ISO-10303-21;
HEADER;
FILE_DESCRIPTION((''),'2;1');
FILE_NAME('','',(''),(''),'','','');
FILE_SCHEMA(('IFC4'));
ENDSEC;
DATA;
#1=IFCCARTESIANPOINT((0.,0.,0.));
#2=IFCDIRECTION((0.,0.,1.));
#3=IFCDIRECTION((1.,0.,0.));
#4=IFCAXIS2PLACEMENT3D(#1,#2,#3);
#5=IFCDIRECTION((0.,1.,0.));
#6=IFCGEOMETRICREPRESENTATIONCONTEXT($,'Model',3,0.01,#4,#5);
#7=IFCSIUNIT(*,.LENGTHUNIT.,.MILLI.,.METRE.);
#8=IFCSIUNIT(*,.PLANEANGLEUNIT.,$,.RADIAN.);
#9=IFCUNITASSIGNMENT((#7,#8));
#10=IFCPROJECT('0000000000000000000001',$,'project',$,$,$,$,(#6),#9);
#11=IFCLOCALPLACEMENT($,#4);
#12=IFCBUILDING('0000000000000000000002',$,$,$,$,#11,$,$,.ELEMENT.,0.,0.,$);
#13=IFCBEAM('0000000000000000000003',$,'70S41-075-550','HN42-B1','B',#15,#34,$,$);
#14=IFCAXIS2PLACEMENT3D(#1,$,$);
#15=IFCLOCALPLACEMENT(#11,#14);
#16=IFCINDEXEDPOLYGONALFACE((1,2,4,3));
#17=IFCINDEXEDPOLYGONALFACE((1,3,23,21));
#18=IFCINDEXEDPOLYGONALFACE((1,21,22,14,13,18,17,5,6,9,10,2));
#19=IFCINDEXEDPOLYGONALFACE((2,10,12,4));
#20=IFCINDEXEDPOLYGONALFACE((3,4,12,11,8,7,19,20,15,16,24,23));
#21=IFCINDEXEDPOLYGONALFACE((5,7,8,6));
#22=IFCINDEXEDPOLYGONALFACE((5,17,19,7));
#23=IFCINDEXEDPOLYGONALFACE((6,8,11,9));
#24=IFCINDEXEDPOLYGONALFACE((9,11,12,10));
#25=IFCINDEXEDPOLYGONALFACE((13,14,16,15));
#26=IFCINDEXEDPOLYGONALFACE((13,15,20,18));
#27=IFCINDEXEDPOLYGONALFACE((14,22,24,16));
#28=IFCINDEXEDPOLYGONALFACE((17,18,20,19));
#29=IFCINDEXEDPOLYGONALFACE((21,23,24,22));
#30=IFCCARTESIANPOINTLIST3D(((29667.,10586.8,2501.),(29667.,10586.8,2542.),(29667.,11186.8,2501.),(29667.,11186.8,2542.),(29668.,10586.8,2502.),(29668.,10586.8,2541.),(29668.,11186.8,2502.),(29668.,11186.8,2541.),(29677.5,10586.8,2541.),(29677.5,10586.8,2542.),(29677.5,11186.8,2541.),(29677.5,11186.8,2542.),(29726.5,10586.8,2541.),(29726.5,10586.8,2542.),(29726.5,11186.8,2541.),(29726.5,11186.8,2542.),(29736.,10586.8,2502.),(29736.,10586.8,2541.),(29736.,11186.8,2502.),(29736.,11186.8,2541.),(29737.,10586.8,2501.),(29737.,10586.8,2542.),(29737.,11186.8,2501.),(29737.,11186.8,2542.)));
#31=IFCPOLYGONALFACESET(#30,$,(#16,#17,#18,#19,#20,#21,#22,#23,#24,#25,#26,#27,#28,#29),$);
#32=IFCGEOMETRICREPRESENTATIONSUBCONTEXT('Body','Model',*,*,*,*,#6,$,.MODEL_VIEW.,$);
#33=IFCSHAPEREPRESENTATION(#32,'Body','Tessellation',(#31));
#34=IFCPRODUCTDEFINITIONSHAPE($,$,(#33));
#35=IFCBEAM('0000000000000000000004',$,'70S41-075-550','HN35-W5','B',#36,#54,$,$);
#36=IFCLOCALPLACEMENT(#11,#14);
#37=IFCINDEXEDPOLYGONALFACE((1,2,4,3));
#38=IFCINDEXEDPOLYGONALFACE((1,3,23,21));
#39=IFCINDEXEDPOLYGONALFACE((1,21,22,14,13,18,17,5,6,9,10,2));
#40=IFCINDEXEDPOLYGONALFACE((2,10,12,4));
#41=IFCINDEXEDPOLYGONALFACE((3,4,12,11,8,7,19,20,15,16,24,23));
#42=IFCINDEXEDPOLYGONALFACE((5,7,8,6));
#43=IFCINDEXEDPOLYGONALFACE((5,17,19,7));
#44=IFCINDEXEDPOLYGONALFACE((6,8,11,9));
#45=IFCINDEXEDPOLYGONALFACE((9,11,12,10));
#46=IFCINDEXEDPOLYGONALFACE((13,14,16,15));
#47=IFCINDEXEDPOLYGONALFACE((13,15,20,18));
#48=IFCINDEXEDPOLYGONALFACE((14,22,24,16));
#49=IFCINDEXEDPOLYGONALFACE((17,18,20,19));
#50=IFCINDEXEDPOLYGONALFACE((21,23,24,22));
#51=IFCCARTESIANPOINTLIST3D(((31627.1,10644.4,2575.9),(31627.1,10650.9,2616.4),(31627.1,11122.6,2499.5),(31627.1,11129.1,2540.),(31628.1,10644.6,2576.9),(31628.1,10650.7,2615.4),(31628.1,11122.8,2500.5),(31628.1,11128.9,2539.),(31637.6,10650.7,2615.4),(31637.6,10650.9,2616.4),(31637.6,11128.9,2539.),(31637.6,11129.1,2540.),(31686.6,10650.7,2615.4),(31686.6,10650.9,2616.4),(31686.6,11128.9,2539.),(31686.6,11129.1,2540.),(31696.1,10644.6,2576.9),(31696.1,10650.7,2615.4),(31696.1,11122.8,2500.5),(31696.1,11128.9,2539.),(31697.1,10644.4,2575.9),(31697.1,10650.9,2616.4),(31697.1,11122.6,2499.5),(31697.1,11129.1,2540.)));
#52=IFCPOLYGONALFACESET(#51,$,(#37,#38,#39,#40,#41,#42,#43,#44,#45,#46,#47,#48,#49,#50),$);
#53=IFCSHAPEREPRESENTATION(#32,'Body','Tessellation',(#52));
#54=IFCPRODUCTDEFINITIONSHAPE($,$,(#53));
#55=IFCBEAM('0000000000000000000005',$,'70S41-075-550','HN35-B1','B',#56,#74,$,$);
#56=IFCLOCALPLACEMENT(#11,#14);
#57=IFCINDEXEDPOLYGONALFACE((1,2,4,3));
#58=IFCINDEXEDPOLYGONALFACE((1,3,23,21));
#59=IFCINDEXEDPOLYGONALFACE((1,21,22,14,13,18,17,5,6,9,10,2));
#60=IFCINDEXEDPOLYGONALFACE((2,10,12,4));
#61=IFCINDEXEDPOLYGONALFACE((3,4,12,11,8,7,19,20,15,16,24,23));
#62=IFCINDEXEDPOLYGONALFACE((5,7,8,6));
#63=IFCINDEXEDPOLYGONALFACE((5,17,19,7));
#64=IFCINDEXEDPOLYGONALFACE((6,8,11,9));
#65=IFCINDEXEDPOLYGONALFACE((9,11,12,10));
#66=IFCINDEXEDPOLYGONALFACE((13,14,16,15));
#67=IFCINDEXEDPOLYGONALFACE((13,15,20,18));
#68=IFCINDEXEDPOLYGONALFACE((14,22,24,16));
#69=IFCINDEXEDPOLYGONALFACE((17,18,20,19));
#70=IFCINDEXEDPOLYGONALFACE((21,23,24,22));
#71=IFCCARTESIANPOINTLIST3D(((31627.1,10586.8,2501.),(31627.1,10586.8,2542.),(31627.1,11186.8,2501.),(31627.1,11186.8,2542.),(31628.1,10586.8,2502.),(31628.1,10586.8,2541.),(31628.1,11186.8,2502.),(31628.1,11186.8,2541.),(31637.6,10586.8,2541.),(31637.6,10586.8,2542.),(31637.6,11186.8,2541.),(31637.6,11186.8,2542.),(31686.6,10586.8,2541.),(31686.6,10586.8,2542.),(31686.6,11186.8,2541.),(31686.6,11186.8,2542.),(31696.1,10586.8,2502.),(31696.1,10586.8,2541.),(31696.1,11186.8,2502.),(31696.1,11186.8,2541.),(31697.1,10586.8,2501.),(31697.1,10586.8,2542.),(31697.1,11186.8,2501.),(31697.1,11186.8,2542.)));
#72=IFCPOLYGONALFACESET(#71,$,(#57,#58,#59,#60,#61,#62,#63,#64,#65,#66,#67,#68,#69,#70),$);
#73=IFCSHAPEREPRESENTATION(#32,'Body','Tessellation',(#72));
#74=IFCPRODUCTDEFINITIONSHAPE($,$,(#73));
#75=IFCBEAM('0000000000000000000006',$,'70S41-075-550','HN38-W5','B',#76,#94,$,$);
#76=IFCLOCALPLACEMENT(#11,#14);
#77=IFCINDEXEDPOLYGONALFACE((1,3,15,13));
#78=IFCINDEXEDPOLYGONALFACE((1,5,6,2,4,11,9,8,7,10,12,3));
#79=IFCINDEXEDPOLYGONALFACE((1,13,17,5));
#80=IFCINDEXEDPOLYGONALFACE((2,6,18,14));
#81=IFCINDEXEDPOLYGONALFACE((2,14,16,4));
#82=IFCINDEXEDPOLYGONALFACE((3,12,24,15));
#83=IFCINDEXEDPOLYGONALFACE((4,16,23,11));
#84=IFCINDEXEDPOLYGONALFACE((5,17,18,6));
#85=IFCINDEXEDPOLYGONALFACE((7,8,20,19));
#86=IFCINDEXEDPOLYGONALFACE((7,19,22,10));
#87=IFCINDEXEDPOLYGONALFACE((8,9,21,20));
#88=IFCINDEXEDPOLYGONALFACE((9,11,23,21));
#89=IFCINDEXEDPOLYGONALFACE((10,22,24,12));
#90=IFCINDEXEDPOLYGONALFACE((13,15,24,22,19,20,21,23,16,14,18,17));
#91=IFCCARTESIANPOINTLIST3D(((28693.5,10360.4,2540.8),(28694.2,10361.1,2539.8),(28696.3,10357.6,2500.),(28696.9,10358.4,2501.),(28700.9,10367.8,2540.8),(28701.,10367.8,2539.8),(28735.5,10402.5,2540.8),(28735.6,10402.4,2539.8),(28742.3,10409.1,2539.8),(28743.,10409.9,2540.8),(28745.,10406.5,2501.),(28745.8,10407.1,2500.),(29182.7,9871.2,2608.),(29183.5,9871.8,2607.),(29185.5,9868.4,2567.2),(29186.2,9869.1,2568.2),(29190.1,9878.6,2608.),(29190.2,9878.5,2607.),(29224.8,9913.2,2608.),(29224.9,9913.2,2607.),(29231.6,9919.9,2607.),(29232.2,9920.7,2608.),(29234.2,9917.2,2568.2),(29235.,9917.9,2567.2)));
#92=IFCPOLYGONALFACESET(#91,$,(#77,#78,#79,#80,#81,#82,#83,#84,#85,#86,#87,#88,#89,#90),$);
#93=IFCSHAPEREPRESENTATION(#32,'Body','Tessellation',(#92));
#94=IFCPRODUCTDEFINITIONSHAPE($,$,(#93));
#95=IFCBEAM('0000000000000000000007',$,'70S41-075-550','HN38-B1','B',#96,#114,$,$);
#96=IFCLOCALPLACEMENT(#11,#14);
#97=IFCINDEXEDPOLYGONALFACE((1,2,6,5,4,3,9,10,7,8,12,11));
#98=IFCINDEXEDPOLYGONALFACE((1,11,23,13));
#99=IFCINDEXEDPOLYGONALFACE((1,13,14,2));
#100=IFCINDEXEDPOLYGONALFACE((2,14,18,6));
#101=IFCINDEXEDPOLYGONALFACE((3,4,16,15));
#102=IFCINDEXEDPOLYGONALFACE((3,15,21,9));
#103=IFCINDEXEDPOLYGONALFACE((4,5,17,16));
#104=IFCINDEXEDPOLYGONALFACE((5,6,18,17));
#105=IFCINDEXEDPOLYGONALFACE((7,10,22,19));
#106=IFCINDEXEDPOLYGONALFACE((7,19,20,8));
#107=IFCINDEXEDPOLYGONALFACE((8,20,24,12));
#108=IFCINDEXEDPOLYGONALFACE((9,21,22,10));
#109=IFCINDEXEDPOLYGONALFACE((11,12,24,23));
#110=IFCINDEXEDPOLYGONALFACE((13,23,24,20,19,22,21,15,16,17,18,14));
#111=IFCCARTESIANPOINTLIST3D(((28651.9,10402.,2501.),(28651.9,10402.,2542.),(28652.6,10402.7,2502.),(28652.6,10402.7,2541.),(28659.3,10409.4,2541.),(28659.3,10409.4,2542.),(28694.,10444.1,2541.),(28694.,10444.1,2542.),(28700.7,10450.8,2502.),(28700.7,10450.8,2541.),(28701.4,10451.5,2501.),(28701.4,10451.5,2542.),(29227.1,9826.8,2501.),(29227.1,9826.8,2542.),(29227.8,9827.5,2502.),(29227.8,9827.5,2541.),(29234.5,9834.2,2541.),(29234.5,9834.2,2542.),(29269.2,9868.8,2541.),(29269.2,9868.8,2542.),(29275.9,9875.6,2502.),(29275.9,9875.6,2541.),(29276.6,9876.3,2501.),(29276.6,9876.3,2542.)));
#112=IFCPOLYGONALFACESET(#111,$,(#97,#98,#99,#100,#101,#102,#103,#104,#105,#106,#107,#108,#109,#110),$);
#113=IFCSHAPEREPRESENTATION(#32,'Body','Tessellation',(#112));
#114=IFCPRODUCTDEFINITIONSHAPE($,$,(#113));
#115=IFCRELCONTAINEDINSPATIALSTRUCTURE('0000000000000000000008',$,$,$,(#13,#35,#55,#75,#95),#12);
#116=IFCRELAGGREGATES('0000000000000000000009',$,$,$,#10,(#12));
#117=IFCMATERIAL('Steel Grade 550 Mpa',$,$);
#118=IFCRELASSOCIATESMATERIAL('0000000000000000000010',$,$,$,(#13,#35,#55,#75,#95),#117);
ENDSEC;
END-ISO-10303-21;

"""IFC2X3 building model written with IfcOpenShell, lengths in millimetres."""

from ifc_helpers import new_model, si_unit, direction, frame, origin, origin_with_axes, origin_2d_with_axis, place, context, subcontext, project, spatial, c_section, extrude, source, transform, mapped, material, element, save


model = new_model("IFC2X3")

# Units and contexts
model_context = context("Model", 3, precision=0.01, world=origin_with_axes(), true_north=direction((0.0, 1.0, 0.0)))
body_context = subcontext(model_context, "Body", "Model", "MODEL_VIEW")
ifc_project = project(units=[si_unit("LENGTHUNIT", "METRE", prefix="MILLI"), si_unit("PLANEANGLEUNIT", "RADIAN")], contexts=[model_context])

# Building
building_placement = place(None, origin_with_axes())
building = spatial("IfcBuilding", under=ifc_project, at=building_placement, CompositionType="ELEMENT", ElevationOfRefHeight=0.0, ElevationOfTerrain=0.0)

# Shared definitions
ifc_material = material(Name="Steel Grade 550 Mpa")

# Beams
shared_shape_1 = source(origin(), body_context, "Body", "SweptSolid", [
    extrude(c_section(Depth=70.0, Width=41.0, WallThickness=1.0, Girth=10.5, at=origin_2d_with_axis()), origin_with_axes(), (0.0, 0.0, 1.0), 600.0),
])
beam_1_placement = place(None, frame((29702.0, 10586.8, 2521.5), z_axis=(0.0, 1.0, 0.0), x_axis=(0.0, 0.0, 1.0)))
element("IfcBeam", 1, at=beam_1_placement, inside=building, material=ifc_material, Name="70S41-075-550", Description="HN42-B1", ObjectType="B", context=body_context, shape_type="MappedRepresentation", body=[
    mapped(shared_shape_1, transform((0.0, 0.0, 0.0), scale=1.0)),
])
shared_shape_2 = source(origin(), body_context, "Body", "SweptSolid", [
    extrude(c_section(Depth=70.0, Width=41.0, WallThickness=1.0, Girth=10.5, at=origin_2d_with_axis()), origin_with_axes(), (0.0, 0.0, 1.0), 484.3),
])
beam_2_placement = place(None, frame((31662.1, 10647.6, 2596.1), z_axis=(0.0, 0.987487, -0.157701), x_axis=(0.0, 0.157701, 0.987487)))
element("IfcBeam", 2, at=beam_2_placement, inside=building, material=ifc_material, Name="70S41-075-550", Description="HN35-W5", ObjectType="B", context=body_context, shape_type="MappedRepresentation", body=[
    mapped(shared_shape_2, transform((0.0, 0.0, 0.0), scale=1.0)),
])
shared_shape_3 = source(origin(), body_context, "Body", "SweptSolid", [
    extrude(c_section(Depth=70.0, Width=41.0, WallThickness=1.0, Girth=10.5, at=origin_2d_with_axis()), origin_with_axes(), (0.0, 0.0, 1.0), 600.0),
])
beam_3_placement = place(None, frame((31662.1, 10586.8, 2521.5), z_axis=(0.0, 1.0, 0.0), x_axis=(0.0, 0.0, 1.0)))
element("IfcBeam", 3, at=beam_3_placement, inside=building, material=ifc_material, Name="70S41-075-550", Description="HN35-B1", ObjectType="B", context=body_context, shape_type="MappedRepresentation", body=[
    mapped(shared_shape_3, transform((0.0, 0.0, 0.0), scale=1.0)),
])
shared_shape_4 = source(origin(), body_context, "Body", "SweptSolid", [
    extrude(c_section(Depth=70.0, Width=41.0, WallThickness=1.0, Girth=10.5, at=origin_2d_with_axis()), origin_with_axes(), (0.0, 0.0, 1.0), 695.1),
])
beam_4_placement = place(None, frame((29208.9, 9894.5, 2587.6), z_axis=(-0.703799, 0.703799, -0.09661), x_axis=(-0.068314, 0.068314, 0.995322)))
element("IfcBeam", 4, at=beam_4_placement, inside=building, material=ifc_material, Name="70S41-075-550", Description="HN38-W5", ObjectType="B", context=body_context, shape_type="MappedRepresentation", body=[
    mapped(shared_shape_4, transform((0.0, 0.0, 0.0), scale=1.0)),
])
shared_shape_5 = source(origin(), body_context, "Body", "SweptSolid", [
    extrude(c_section(Depth=70.0, Width=41.0, WallThickness=1.0, Girth=10.5, at=origin_2d_with_axis()), origin_with_axes(), (0.0, 0.0, 1.0), 813.5),
])
beam_5_placement = place(None, frame((29251.9, 9851.5, 2521.5), z_axis=(-0.707107, 0.707107, 0.0), x_axis=(0.0, 0.0, 1.0)))
element("IfcBeam", 5, at=beam_5_placement, inside=building, material=ifc_material, Name="70S41-075-550", Description="HN38-B1", ObjectType="B", context=body_context, shape_type="MappedRepresentation", body=[
    mapped(shared_shape_5, transform((0.0, 0.0, 0.0), scale=1.0)),
])

save(model, "model.ifc")
